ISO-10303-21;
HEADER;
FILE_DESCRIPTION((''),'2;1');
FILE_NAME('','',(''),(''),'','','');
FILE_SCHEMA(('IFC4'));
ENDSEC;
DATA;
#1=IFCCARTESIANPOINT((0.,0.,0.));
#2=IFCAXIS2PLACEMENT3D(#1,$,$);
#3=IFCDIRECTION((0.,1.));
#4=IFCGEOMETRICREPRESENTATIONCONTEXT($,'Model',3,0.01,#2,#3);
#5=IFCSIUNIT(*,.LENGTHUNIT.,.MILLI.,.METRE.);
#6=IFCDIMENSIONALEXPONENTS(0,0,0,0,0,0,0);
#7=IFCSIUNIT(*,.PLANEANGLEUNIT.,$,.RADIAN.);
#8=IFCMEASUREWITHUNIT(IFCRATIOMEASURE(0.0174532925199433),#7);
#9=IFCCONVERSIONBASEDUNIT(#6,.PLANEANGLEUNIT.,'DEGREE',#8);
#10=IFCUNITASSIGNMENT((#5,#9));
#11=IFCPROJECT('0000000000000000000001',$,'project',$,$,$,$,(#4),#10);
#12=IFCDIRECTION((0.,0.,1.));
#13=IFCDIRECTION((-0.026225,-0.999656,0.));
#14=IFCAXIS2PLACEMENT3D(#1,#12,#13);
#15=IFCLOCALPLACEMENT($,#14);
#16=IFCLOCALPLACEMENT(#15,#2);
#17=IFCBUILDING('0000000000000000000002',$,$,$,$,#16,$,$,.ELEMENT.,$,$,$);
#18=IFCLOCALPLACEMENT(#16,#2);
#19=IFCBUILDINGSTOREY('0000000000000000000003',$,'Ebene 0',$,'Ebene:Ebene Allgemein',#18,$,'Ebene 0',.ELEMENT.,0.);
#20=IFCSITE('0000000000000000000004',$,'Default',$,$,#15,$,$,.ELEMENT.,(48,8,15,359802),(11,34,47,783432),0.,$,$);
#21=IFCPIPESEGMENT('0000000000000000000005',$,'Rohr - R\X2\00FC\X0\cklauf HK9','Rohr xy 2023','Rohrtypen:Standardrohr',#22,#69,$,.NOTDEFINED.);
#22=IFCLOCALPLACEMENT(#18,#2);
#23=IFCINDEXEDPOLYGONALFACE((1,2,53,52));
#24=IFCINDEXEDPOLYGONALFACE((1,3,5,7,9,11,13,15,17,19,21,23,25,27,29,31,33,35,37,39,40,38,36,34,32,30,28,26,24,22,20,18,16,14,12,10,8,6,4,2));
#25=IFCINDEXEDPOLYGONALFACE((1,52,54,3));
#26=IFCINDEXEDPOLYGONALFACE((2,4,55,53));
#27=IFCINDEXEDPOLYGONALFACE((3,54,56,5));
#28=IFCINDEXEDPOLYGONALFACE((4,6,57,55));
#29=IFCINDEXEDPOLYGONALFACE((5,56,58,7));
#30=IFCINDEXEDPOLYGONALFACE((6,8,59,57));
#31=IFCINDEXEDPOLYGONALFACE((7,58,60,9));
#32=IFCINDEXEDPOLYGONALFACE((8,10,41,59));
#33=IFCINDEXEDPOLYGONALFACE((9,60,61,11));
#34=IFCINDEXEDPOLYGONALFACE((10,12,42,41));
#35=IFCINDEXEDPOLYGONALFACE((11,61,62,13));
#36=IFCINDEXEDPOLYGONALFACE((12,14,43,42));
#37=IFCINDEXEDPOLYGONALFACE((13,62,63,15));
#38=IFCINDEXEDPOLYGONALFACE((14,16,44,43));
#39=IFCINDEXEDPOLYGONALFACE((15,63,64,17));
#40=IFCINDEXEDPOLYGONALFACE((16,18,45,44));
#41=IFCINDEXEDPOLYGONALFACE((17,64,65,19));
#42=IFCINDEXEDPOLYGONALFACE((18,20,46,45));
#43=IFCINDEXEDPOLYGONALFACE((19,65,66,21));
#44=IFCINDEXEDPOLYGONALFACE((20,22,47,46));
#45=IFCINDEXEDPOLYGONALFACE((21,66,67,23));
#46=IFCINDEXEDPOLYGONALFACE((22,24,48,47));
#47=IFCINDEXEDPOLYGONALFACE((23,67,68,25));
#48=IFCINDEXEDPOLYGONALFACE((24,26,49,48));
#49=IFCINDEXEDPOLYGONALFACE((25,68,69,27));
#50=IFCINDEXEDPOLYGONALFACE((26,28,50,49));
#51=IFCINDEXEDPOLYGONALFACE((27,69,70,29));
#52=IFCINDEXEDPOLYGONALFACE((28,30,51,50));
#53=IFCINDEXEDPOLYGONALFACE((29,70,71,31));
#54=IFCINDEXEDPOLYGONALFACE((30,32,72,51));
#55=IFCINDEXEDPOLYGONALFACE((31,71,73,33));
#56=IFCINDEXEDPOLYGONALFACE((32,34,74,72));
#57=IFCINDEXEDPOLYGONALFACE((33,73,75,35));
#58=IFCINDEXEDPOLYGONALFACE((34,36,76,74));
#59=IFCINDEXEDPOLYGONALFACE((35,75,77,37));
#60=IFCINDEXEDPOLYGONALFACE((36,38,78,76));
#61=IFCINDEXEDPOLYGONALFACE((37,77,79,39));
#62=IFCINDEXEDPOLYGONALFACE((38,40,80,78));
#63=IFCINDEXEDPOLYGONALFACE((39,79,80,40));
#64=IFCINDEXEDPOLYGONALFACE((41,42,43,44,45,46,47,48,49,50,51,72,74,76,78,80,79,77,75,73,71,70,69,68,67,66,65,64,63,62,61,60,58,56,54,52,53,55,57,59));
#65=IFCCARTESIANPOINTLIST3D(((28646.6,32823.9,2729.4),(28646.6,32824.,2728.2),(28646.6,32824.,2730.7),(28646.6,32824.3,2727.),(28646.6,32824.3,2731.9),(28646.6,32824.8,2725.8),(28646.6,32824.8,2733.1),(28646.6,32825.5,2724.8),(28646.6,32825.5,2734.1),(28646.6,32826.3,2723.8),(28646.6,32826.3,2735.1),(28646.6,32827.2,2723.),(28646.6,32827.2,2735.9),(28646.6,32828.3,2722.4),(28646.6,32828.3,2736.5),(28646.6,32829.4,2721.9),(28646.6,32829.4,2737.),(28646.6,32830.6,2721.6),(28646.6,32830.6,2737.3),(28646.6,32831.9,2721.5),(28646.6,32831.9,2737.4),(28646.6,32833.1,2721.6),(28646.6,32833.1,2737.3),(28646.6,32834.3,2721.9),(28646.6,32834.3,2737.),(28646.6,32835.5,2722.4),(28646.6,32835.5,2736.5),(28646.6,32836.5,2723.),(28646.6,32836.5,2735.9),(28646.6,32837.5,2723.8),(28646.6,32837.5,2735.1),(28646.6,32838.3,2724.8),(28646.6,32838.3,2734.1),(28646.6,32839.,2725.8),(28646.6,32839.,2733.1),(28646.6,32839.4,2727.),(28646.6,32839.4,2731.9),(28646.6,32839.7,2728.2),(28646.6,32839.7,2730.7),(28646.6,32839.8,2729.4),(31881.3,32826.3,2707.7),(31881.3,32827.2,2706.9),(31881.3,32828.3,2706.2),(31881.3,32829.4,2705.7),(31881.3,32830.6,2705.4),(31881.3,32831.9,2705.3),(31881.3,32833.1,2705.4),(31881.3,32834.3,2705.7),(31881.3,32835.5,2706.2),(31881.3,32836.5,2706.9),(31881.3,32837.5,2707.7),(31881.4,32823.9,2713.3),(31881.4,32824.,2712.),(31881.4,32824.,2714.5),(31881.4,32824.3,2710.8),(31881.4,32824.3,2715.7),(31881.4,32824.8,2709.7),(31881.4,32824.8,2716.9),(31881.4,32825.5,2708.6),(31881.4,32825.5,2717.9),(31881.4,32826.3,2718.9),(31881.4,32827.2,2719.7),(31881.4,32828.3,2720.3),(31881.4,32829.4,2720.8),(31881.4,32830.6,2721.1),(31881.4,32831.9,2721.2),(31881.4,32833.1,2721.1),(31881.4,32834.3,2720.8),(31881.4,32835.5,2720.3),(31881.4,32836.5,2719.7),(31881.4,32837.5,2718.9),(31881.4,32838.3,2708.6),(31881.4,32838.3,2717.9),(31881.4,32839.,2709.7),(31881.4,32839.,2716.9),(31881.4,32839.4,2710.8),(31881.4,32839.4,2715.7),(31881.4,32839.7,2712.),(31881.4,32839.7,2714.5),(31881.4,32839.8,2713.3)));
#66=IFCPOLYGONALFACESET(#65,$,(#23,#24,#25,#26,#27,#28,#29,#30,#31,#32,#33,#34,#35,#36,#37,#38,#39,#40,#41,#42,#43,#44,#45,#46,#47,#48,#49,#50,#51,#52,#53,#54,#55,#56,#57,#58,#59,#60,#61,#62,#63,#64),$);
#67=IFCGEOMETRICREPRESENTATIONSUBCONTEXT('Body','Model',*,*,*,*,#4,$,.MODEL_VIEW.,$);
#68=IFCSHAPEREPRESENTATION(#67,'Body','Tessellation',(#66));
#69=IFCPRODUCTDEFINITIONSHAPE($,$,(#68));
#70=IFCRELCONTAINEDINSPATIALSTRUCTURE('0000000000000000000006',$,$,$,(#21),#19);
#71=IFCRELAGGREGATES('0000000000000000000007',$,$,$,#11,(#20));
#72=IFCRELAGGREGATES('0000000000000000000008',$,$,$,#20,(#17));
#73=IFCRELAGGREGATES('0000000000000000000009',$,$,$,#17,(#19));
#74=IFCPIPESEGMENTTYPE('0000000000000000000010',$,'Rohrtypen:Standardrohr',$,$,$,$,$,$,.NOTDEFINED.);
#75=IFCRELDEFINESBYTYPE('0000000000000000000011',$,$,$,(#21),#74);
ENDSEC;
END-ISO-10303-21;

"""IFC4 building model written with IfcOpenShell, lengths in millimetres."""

from ifc_helpers import new_model, entity, si_unit, converted_unit, direction, frame, origin, place, context, subcontext, project, spatial, indexed_curve, outline, extrude, type_object, element, save


model = new_model("IFC4")

# Units and contexts
model_context = context("Model", 3, precision=0.01, world=origin(), true_north=direction((0.0, 1.0)))
body_context = subcontext(model_context, "Body", "Model", "MODEL_VIEW")
ifc_project = project(units=[si_unit("LENGTHUNIT", "METRE", prefix="MILLI"), converted_unit("PLANEANGLEUNIT", "DEGREE", entity("IfcRatioMeasure", 0.0174532925199433), si_unit("PLANEANGLEUNIT", "RADIAN"), dimensions=[0, 0, 0, 0, 0, 0, 0])], contexts=[model_context])

# Site, building, storey
site_placement = place(None, frame((0.0, 0.0, 0.0), z_axis=(0.0, 0.0, 1.0), x_axis=(-0.026225, -0.999656, 0.0)))
site = spatial("IfcSite", under=ifc_project, at=site_placement, Name="Default", CompositionType="ELEMENT", RefLatitude=(48, 8, 15, 359802), RefLongitude=(11, 34, 47, 783432), RefElevation=0.0)
building_placement = place(site_placement, origin())
building = spatial("IfcBuilding", under=site, at=building_placement, CompositionType="ELEMENT")
storey_placement = place(building_placement, origin())
storey = spatial("IfcBuildingStorey", under=building, at=storey_placement, Name="Ebene 0", ObjectType="Ebene:Ebene Allgemein", LongName="Ebene 0", CompositionType="ELEMENT", Elevation=0.0)

# Pipe segment
pipe_segment_type = type_object("IfcPipeSegmentType", Name="Rohrtypen:Standardrohr", PredefinedType="NOTDEFINED")
pipe_segment_1_placement = place(storey_placement, origin())
element("IfcPipeSegment", 1, at=pipe_segment_1_placement, inside=storey, type_object=pipe_segment_type, Name="Rohr - Rücklauf HK9", Description="Rohr xy 2023", ObjectType="Rohrtypen:Standardrohr", PredefinedType="NOTDEFINED", context=body_context, shape_type="SweptSolid", body=[
    extrude(outline(indexed_curve([(7.9, 0.0), (7.8, 1.2), (7.6, 2.5), (7.1, 3.6), (6.4, 4.7), (5.6, 5.6), (4.7, 6.4), (3.6, 7.1), (2.5, 7.6), (1.2, 7.8), (0.0, 7.9), (-1.2, 7.8), (-2.5, 7.6), (-3.6, 7.1), (-4.7, 6.4), (-5.6, 5.6), (-6.4, 4.7), (-7.1, 3.6), (-7.6, 2.5), (-7.8, 1.2), (-7.9, 0.0), (-7.8, -1.2), (-7.6, -2.5), (-7.1, -3.6), (-6.4, -4.7), (-5.6, -5.6), (-4.7, -6.4), (-3.6, -7.1), (-2.5, -7.6), (-1.2, -7.8), (0.0, -7.9), (1.2, -7.8), (2.5, -7.6), (3.6, -7.1), (4.7, -6.4), (5.6, -5.6), (6.4, -4.7), (7.1, -3.6), (7.6, -2.5), (7.8, -1.2), (7.9, 0.0)], self_intersect=False)), frame((31881.4, 32831.9, 2713.3), z_axis=(-0.999988, 0.0, 0.005), x_axis=(0.0, 1.0, 0.0)), (0.0, 0.0, 1.0), 3234.8),
])

save(model, "model.ifc")
